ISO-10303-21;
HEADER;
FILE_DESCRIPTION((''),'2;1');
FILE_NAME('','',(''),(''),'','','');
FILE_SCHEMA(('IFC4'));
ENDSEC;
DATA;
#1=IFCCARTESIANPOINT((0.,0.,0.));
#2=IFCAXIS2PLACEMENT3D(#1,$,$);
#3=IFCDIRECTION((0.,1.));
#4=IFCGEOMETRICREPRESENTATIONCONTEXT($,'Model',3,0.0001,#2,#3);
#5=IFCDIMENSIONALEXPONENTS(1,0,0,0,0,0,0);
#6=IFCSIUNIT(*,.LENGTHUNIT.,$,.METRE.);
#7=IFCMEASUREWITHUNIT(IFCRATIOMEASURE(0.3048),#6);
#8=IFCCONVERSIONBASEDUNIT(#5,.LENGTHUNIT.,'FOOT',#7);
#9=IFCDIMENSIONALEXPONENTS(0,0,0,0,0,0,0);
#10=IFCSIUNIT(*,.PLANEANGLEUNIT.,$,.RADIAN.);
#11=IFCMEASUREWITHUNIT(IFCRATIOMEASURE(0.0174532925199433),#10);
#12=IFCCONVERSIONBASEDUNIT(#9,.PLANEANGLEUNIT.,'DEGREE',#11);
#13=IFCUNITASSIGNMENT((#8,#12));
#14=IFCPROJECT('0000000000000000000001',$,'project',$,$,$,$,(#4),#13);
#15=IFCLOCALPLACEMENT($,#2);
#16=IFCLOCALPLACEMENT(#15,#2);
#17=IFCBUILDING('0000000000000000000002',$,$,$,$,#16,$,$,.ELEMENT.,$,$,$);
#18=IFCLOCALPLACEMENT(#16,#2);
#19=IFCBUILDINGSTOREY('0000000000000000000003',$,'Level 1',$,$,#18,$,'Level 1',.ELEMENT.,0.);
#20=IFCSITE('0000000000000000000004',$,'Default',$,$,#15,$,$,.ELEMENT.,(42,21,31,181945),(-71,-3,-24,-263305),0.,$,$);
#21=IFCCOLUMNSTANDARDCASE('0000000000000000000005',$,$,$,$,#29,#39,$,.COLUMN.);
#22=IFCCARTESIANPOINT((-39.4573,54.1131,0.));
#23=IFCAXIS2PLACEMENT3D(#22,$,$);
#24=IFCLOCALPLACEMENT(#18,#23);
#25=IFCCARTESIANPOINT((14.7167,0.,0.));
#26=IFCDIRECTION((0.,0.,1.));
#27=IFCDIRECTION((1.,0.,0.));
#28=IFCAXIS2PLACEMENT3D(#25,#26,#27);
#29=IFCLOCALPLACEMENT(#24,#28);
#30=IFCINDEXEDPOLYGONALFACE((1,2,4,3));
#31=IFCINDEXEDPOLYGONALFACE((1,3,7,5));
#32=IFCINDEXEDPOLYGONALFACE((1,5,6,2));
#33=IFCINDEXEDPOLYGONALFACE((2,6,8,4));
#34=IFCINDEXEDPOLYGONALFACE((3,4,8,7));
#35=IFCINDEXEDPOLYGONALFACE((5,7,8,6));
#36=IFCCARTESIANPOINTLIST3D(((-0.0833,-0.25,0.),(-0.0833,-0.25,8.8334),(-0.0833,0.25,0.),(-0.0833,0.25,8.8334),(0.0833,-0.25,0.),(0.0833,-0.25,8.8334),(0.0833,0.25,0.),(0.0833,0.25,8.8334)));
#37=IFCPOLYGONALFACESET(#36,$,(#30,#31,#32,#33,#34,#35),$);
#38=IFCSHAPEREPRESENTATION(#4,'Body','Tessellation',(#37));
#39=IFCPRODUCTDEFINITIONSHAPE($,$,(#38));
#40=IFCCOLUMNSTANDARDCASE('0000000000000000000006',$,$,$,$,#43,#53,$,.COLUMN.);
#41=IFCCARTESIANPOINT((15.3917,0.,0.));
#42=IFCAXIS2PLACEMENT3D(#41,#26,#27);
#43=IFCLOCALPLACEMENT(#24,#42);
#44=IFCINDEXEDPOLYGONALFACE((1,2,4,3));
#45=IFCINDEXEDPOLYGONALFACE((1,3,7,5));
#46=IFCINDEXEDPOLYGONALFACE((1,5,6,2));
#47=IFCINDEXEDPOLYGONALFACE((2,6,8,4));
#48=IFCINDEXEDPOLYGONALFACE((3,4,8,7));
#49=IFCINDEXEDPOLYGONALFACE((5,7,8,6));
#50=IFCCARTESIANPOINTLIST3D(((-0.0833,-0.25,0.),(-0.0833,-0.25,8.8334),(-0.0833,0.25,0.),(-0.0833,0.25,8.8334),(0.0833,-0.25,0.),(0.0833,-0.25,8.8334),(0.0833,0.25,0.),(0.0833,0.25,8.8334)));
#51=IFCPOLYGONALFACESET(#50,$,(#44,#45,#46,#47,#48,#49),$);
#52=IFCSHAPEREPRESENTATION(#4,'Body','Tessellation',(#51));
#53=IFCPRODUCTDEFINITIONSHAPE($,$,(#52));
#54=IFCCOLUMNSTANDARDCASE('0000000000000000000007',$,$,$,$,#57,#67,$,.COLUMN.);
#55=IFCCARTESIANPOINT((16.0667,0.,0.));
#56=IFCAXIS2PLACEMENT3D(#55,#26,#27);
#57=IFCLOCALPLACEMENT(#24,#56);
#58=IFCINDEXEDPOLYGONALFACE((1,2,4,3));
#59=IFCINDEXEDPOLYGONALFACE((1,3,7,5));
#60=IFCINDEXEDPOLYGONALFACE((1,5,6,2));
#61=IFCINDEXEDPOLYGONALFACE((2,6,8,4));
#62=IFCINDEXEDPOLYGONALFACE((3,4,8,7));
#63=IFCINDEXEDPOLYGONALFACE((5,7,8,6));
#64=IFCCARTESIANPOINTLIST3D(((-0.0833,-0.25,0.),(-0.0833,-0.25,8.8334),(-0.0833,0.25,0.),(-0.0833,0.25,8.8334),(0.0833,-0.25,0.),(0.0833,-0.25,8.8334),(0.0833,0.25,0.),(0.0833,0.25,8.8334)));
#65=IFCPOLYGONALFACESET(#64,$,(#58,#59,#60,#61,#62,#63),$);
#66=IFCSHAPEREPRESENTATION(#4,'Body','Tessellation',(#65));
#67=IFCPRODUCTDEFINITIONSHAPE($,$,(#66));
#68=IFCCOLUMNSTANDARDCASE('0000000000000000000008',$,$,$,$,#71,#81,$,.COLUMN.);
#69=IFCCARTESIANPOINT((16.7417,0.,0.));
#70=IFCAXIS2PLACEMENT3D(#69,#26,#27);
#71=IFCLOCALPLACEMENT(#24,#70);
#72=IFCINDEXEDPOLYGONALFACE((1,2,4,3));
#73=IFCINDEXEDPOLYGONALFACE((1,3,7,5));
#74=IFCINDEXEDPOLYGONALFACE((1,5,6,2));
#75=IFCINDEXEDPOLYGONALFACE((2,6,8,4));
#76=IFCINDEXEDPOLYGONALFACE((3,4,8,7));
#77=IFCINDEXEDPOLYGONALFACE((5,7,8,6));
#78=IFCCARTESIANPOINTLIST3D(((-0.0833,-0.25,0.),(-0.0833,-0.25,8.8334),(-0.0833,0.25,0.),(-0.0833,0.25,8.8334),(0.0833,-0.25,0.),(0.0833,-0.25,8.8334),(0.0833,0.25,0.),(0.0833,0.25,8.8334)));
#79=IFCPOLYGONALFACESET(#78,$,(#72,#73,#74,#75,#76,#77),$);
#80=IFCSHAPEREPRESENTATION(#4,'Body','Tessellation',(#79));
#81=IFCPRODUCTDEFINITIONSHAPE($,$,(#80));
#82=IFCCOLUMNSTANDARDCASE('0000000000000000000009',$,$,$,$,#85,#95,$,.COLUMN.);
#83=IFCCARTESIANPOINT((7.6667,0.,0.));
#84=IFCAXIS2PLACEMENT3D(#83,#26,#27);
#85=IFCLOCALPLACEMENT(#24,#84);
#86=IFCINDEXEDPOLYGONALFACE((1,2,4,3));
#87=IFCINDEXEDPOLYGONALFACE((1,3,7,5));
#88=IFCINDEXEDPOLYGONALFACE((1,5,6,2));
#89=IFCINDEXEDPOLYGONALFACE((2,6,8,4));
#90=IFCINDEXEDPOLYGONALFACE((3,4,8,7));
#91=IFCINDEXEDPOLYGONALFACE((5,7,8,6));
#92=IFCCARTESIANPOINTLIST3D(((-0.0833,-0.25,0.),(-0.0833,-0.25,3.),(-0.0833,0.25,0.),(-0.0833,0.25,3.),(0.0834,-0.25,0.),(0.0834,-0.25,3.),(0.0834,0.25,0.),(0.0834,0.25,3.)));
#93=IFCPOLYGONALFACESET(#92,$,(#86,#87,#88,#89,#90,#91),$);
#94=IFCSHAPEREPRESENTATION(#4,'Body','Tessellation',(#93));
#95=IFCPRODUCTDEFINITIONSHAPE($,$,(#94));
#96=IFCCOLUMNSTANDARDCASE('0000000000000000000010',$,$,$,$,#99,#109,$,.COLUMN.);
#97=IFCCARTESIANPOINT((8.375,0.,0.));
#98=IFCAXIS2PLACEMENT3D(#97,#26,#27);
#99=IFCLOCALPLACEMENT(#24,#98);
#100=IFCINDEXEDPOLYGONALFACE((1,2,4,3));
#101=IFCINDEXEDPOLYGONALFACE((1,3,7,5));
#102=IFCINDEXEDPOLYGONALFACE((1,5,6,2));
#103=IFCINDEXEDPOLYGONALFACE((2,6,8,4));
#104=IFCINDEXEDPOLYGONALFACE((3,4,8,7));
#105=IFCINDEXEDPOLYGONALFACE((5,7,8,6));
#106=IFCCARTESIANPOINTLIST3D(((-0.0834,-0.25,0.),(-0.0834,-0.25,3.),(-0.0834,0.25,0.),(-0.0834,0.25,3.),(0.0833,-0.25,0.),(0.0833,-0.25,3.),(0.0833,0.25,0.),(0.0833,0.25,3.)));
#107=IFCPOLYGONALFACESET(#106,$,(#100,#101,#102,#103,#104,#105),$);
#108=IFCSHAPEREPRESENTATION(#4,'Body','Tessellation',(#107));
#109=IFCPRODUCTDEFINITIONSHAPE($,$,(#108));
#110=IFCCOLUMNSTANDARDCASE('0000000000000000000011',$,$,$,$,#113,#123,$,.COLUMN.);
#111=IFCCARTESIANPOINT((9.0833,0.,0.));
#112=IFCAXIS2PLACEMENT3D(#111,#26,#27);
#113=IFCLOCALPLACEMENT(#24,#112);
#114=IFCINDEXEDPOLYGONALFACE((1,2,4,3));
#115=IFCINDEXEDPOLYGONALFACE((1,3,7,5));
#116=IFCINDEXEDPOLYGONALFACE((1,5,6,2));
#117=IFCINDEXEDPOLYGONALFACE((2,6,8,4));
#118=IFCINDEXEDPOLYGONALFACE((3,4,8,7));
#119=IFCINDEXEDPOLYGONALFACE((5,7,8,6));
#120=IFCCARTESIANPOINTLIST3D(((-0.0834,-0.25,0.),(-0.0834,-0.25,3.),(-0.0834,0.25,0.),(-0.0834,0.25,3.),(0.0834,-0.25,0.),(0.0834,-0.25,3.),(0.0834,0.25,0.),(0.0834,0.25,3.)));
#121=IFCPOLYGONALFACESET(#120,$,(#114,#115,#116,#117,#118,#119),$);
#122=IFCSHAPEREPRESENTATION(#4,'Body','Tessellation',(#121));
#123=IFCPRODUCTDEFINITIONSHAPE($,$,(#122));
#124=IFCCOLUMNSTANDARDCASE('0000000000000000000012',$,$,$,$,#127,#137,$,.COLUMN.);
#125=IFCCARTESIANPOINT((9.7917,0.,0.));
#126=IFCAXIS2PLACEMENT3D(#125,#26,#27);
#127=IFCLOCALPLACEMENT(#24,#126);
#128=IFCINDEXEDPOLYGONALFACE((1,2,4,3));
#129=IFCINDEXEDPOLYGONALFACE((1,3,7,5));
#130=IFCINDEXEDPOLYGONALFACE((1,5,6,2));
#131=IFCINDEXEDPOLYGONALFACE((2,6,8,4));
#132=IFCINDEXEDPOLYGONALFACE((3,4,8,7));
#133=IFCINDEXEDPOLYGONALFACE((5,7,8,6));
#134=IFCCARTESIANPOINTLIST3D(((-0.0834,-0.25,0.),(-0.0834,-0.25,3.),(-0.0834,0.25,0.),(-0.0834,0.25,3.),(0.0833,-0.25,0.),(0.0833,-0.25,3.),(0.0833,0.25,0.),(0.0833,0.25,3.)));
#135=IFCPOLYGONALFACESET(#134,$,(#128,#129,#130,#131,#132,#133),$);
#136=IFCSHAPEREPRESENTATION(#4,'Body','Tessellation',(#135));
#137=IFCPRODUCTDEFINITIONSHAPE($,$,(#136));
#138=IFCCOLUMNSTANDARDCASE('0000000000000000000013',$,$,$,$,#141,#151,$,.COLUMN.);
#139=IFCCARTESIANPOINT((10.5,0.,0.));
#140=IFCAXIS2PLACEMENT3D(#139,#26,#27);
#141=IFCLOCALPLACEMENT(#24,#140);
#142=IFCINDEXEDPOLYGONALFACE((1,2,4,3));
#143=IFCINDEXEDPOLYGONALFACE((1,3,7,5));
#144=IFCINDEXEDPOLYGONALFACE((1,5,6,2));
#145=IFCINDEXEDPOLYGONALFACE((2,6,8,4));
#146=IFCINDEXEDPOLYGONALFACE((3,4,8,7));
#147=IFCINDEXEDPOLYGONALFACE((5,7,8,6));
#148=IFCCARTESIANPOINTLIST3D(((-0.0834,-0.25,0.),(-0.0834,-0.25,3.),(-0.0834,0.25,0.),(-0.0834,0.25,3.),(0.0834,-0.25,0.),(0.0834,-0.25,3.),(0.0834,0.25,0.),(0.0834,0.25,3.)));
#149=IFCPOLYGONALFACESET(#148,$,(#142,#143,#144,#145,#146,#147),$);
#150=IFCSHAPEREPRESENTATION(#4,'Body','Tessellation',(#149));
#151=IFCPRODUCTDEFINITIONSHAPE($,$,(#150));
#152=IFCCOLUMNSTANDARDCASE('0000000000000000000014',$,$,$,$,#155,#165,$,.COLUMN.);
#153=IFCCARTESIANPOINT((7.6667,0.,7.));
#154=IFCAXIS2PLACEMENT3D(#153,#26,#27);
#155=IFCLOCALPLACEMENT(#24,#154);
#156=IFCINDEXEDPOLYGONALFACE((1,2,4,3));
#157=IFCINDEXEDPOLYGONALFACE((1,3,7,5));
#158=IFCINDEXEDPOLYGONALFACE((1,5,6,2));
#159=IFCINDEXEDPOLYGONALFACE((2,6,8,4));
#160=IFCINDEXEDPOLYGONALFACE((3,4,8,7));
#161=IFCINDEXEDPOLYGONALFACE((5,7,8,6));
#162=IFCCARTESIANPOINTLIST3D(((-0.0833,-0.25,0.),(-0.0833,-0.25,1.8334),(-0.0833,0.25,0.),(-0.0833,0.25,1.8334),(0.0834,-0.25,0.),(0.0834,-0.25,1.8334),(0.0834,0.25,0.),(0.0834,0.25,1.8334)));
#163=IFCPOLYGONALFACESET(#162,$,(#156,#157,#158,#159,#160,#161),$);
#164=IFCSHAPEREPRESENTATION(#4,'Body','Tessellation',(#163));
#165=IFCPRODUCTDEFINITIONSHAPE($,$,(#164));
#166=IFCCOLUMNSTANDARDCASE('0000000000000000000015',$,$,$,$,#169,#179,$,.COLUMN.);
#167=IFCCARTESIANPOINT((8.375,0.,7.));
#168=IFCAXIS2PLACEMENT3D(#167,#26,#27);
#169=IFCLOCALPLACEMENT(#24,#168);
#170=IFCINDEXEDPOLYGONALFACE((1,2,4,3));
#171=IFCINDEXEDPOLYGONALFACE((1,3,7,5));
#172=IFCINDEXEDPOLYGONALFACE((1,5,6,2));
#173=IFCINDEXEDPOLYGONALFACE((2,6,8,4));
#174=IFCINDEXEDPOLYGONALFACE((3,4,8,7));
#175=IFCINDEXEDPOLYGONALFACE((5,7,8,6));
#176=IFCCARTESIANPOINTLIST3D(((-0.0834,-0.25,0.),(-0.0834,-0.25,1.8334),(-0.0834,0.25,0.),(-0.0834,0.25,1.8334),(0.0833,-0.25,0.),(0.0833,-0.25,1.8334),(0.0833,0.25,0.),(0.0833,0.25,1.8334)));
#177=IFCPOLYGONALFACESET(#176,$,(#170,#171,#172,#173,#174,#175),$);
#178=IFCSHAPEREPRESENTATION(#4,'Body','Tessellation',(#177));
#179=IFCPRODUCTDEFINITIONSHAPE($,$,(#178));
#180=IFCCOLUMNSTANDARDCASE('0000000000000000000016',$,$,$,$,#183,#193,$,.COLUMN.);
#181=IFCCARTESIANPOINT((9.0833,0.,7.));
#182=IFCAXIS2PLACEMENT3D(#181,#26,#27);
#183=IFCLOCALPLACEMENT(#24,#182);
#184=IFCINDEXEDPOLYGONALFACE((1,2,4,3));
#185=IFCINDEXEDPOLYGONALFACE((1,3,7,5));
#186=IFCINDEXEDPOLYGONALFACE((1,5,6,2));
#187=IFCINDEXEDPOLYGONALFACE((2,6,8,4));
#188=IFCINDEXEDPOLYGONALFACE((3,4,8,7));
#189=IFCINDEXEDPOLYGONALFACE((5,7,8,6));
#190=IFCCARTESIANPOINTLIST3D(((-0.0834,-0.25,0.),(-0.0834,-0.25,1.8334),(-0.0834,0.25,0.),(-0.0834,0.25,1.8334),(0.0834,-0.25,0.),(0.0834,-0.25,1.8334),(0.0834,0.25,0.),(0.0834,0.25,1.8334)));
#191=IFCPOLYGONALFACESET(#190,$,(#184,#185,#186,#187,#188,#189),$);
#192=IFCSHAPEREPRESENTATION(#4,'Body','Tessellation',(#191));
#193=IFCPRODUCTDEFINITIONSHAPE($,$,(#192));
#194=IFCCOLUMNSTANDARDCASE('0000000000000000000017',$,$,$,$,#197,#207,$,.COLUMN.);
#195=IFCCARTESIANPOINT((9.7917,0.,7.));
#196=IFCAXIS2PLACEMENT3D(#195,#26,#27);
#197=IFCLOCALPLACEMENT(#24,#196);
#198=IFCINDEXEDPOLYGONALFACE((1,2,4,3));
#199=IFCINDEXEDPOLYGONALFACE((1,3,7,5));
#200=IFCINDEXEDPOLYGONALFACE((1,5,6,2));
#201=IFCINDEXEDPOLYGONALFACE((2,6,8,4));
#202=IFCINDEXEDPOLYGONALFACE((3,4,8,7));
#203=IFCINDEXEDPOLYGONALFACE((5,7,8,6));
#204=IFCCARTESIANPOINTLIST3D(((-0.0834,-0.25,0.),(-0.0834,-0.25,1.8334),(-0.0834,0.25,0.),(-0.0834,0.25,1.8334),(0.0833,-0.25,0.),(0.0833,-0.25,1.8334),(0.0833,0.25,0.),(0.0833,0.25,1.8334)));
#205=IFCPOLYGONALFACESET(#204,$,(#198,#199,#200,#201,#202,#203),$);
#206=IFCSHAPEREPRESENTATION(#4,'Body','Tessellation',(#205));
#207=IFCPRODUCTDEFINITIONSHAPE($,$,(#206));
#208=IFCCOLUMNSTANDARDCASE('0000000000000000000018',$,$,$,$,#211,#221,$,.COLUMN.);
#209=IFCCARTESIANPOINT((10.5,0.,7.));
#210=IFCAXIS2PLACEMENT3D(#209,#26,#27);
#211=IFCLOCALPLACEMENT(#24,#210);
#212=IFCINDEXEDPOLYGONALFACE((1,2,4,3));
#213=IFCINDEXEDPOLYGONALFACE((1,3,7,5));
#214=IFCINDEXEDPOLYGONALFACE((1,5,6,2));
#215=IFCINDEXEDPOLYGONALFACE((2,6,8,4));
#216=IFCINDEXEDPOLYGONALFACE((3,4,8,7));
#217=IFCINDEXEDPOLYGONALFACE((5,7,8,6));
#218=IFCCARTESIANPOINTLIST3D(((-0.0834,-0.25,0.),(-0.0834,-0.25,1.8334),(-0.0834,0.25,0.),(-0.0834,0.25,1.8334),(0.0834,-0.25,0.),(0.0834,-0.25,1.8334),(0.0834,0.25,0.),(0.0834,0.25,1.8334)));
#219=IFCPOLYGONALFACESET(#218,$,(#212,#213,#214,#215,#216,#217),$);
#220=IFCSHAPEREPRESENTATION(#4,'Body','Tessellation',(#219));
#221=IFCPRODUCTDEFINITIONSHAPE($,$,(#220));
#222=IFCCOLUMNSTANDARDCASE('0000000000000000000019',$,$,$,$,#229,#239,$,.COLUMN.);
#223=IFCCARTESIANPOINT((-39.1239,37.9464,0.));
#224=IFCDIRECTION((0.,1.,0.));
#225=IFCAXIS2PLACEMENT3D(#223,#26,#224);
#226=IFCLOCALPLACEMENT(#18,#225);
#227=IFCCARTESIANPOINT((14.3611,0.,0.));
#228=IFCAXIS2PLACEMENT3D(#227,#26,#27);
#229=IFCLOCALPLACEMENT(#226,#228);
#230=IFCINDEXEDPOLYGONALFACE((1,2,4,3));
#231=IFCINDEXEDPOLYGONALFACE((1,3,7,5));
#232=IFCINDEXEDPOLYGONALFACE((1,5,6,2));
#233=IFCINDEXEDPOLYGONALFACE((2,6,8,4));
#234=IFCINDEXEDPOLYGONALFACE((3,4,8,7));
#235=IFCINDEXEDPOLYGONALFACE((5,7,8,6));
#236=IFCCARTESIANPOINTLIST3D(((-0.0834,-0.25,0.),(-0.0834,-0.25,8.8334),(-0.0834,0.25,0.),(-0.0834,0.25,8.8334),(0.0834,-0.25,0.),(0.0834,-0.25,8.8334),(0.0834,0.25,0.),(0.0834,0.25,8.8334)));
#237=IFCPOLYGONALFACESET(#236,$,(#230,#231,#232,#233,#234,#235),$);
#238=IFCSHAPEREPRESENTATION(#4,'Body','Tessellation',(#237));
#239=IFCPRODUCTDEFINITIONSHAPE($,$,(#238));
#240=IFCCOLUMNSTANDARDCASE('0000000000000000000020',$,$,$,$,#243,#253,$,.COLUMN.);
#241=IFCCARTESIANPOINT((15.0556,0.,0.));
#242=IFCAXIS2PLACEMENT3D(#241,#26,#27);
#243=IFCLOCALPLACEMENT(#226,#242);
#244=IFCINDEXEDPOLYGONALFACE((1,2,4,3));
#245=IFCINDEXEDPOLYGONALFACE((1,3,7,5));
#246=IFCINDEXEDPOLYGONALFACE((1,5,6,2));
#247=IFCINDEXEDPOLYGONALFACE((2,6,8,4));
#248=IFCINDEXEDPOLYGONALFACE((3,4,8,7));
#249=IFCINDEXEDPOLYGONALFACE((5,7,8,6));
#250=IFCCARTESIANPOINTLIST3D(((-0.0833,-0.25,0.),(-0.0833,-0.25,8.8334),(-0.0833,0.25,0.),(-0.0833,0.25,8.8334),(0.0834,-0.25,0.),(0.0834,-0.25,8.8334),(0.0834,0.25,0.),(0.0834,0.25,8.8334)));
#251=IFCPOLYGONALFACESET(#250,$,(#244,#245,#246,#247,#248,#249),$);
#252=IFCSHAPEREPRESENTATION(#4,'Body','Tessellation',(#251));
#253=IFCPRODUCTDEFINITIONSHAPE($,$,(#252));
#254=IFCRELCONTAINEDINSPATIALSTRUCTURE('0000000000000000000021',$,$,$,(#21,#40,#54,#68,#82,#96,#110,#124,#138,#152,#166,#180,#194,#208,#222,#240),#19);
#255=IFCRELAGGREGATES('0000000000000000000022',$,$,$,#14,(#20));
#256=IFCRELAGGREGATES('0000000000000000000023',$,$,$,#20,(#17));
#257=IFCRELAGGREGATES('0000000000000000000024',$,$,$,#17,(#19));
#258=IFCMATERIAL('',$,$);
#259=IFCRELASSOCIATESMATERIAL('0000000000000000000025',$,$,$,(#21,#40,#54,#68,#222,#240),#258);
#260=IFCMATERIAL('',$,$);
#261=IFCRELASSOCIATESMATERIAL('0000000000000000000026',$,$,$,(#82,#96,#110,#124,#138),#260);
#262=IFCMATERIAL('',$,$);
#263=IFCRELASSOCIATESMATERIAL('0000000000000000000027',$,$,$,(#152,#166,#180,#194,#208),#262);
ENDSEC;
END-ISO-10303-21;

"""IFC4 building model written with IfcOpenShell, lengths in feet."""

from ifc_helpers import new_model, entity, si_unit, converted_unit, direction, frame, origin, place, context, project, spatial, rectangle, extrude, material, element, save


model = new_model("IFC4")

# Units and contexts
model_context = context("Model", 3, precision=0.0001, world=origin(), true_north=direction((0.0, 1.0)))
ifc_project = project(units=[converted_unit("LENGTHUNIT", "FOOT", entity("IfcRatioMeasure", 0.3048), si_unit("LENGTHUNIT", "METRE"), dimensions=[1, 0, 0, 0, 0, 0, 0]), converted_unit("PLANEANGLEUNIT", "DEGREE", entity("IfcRatioMeasure", 0.0174532925199433), si_unit("PLANEANGLEUNIT", "RADIAN"), dimensions=[0, 0, 0, 0, 0, 0, 0])], contexts=[model_context])

# Site, building, storey
site_placement = place(None, origin())
site = spatial("IfcSite", under=ifc_project, at=site_placement, Name="Default", CompositionType="ELEMENT", RefLatitude=(42, 21, 31, 181945), RefLongitude=(-71, -3, -24, -263305), RefElevation=0.0)
building_placement = place(site_placement, origin())
building = spatial("IfcBuilding", under=site, at=building_placement, CompositionType="ELEMENT")
storey_placement = place(building_placement, origin())
storey = spatial("IfcBuildingStorey", under=building, at=storey_placement, Name="Level 1", LongName="Level 1", CompositionType="ELEMENT", Elevation=0.0)

# Columns
placement_1 = place(storey_placement, frame((-39.4573, 54.1131, 0.0)))
ifc_material_1 = material(Name="")
for number, where, z_axis, x_axis in (
    (1, (14.7167, 0.0, 0.0), (0.0, 0.0, 1.0), (1.0, 0.0, 0.0)),
    (2, (15.3917, 0.0, 0.0), (0.0, 0.0, 1.0), (1.0, 0.0, 0.0)),
    (3, (16.0667, 0.0, 0.0), (0.0, 0.0, 1.0), (1.0, 0.0, 0.0)),
    (4, (16.7417, 0.0, 0.0), (0.0, 0.0, 1.0), (1.0, 0.0, 0.0)),
):
    element("IfcColumnStandardCase", number, at=place(placement_1, frame(where, z_axis=z_axis, x_axis=x_axis)), inside=storey, material=ifc_material_1, PredefinedType="COLUMN", context=model_context, shape_type="SweptSolid", body=[
        extrude(rectangle(XDim=0.1667, YDim=0.5), origin(), (0.0, 0.0, 1.0), 8.8334),
    ])
ifc_material_2 = material(Name="")
for number, where, z_axis, x_axis in (
    (5, (7.6667, 0.0, 0.0), (0.0, 0.0, 1.0), (1.0, 0.0, 0.0)),
    (6, (8.375, 0.0, 0.0), (0.0, 0.0, 1.0), (1.0, 0.0, 0.0)),
    (7, (9.0833, 0.0, 0.0), (0.0, 0.0, 1.0), (1.0, 0.0, 0.0)),
    (8, (9.7917, 0.0, 0.0), (0.0, 0.0, 1.0), (1.0, 0.0, 0.0)),
    (9, (10.5, 0.0, 0.0), (0.0, 0.0, 1.0), (1.0, 0.0, 0.0)),
):
    element("IfcColumnStandardCase", number, at=place(placement_1, frame(where, z_axis=z_axis, x_axis=x_axis)), inside=storey, material=ifc_material_2, PredefinedType="COLUMN", context=model_context, shape_type="SweptSolid", body=[
        extrude(rectangle(XDim=0.1667, YDim=0.5), origin(), (0.0, 0.0, 1.0), 3.0),
    ])
ifc_material_3 = material(Name="")
for number, where, z_axis, x_axis in (
    (10, (7.6667, 0.0, 7.0), (0.0, 0.0, 1.0), (1.0, 0.0, 0.0)),
    (11, (8.375, 0.0, 7.0), (0.0, 0.0, 1.0), (1.0, 0.0, 0.0)),
    (12, (9.0833, 0.0, 7.0), (0.0, 0.0, 1.0), (1.0, 0.0, 0.0)),
    (13, (9.7917, 0.0, 7.0), (0.0, 0.0, 1.0), (1.0, 0.0, 0.0)),
    (14, (10.5, 0.0, 7.0), (0.0, 0.0, 1.0), (1.0, 0.0, 0.0)),
):
    element("IfcColumnStandardCase", number, at=place(placement_1, frame(where, z_axis=z_axis, x_axis=x_axis)), inside=storey, material=ifc_material_3, PredefinedType="COLUMN", context=model_context, shape_type="SweptSolid", body=[
        extrude(rectangle(XDim=0.1667, YDim=0.5), origin(), (0.0, 0.0, 1.0), 1.8334),
    ])
placement_2 = place(storey_placement, frame((-39.1239, 37.9464, 0.0), z_axis=(0.0, 0.0, 1.0), x_axis=(0.0, 1.0, 0.0)))
for number, where, z_axis, x_axis in (
    (15, (14.3611, 0.0, 0.0), (0.0, 0.0, 1.0), (1.0, 0.0, 0.0)),
    (16, (15.0556, 0.0, 0.0), (0.0, 0.0, 1.0), (1.0, 0.0, 0.0)),
):
    element("IfcColumnStandardCase", number, at=place(placement_2, frame(where, z_axis=z_axis, x_axis=x_axis)), inside=storey, material=ifc_material_1, PredefinedType="COLUMN", context=model_context, shape_type="SweptSolid", body=[
        extrude(rectangle(XDim=0.1667, YDim=0.5), origin(), (0.0, 0.0, 1.0), 8.8334),
    ])

save(model, "model.ifc")
